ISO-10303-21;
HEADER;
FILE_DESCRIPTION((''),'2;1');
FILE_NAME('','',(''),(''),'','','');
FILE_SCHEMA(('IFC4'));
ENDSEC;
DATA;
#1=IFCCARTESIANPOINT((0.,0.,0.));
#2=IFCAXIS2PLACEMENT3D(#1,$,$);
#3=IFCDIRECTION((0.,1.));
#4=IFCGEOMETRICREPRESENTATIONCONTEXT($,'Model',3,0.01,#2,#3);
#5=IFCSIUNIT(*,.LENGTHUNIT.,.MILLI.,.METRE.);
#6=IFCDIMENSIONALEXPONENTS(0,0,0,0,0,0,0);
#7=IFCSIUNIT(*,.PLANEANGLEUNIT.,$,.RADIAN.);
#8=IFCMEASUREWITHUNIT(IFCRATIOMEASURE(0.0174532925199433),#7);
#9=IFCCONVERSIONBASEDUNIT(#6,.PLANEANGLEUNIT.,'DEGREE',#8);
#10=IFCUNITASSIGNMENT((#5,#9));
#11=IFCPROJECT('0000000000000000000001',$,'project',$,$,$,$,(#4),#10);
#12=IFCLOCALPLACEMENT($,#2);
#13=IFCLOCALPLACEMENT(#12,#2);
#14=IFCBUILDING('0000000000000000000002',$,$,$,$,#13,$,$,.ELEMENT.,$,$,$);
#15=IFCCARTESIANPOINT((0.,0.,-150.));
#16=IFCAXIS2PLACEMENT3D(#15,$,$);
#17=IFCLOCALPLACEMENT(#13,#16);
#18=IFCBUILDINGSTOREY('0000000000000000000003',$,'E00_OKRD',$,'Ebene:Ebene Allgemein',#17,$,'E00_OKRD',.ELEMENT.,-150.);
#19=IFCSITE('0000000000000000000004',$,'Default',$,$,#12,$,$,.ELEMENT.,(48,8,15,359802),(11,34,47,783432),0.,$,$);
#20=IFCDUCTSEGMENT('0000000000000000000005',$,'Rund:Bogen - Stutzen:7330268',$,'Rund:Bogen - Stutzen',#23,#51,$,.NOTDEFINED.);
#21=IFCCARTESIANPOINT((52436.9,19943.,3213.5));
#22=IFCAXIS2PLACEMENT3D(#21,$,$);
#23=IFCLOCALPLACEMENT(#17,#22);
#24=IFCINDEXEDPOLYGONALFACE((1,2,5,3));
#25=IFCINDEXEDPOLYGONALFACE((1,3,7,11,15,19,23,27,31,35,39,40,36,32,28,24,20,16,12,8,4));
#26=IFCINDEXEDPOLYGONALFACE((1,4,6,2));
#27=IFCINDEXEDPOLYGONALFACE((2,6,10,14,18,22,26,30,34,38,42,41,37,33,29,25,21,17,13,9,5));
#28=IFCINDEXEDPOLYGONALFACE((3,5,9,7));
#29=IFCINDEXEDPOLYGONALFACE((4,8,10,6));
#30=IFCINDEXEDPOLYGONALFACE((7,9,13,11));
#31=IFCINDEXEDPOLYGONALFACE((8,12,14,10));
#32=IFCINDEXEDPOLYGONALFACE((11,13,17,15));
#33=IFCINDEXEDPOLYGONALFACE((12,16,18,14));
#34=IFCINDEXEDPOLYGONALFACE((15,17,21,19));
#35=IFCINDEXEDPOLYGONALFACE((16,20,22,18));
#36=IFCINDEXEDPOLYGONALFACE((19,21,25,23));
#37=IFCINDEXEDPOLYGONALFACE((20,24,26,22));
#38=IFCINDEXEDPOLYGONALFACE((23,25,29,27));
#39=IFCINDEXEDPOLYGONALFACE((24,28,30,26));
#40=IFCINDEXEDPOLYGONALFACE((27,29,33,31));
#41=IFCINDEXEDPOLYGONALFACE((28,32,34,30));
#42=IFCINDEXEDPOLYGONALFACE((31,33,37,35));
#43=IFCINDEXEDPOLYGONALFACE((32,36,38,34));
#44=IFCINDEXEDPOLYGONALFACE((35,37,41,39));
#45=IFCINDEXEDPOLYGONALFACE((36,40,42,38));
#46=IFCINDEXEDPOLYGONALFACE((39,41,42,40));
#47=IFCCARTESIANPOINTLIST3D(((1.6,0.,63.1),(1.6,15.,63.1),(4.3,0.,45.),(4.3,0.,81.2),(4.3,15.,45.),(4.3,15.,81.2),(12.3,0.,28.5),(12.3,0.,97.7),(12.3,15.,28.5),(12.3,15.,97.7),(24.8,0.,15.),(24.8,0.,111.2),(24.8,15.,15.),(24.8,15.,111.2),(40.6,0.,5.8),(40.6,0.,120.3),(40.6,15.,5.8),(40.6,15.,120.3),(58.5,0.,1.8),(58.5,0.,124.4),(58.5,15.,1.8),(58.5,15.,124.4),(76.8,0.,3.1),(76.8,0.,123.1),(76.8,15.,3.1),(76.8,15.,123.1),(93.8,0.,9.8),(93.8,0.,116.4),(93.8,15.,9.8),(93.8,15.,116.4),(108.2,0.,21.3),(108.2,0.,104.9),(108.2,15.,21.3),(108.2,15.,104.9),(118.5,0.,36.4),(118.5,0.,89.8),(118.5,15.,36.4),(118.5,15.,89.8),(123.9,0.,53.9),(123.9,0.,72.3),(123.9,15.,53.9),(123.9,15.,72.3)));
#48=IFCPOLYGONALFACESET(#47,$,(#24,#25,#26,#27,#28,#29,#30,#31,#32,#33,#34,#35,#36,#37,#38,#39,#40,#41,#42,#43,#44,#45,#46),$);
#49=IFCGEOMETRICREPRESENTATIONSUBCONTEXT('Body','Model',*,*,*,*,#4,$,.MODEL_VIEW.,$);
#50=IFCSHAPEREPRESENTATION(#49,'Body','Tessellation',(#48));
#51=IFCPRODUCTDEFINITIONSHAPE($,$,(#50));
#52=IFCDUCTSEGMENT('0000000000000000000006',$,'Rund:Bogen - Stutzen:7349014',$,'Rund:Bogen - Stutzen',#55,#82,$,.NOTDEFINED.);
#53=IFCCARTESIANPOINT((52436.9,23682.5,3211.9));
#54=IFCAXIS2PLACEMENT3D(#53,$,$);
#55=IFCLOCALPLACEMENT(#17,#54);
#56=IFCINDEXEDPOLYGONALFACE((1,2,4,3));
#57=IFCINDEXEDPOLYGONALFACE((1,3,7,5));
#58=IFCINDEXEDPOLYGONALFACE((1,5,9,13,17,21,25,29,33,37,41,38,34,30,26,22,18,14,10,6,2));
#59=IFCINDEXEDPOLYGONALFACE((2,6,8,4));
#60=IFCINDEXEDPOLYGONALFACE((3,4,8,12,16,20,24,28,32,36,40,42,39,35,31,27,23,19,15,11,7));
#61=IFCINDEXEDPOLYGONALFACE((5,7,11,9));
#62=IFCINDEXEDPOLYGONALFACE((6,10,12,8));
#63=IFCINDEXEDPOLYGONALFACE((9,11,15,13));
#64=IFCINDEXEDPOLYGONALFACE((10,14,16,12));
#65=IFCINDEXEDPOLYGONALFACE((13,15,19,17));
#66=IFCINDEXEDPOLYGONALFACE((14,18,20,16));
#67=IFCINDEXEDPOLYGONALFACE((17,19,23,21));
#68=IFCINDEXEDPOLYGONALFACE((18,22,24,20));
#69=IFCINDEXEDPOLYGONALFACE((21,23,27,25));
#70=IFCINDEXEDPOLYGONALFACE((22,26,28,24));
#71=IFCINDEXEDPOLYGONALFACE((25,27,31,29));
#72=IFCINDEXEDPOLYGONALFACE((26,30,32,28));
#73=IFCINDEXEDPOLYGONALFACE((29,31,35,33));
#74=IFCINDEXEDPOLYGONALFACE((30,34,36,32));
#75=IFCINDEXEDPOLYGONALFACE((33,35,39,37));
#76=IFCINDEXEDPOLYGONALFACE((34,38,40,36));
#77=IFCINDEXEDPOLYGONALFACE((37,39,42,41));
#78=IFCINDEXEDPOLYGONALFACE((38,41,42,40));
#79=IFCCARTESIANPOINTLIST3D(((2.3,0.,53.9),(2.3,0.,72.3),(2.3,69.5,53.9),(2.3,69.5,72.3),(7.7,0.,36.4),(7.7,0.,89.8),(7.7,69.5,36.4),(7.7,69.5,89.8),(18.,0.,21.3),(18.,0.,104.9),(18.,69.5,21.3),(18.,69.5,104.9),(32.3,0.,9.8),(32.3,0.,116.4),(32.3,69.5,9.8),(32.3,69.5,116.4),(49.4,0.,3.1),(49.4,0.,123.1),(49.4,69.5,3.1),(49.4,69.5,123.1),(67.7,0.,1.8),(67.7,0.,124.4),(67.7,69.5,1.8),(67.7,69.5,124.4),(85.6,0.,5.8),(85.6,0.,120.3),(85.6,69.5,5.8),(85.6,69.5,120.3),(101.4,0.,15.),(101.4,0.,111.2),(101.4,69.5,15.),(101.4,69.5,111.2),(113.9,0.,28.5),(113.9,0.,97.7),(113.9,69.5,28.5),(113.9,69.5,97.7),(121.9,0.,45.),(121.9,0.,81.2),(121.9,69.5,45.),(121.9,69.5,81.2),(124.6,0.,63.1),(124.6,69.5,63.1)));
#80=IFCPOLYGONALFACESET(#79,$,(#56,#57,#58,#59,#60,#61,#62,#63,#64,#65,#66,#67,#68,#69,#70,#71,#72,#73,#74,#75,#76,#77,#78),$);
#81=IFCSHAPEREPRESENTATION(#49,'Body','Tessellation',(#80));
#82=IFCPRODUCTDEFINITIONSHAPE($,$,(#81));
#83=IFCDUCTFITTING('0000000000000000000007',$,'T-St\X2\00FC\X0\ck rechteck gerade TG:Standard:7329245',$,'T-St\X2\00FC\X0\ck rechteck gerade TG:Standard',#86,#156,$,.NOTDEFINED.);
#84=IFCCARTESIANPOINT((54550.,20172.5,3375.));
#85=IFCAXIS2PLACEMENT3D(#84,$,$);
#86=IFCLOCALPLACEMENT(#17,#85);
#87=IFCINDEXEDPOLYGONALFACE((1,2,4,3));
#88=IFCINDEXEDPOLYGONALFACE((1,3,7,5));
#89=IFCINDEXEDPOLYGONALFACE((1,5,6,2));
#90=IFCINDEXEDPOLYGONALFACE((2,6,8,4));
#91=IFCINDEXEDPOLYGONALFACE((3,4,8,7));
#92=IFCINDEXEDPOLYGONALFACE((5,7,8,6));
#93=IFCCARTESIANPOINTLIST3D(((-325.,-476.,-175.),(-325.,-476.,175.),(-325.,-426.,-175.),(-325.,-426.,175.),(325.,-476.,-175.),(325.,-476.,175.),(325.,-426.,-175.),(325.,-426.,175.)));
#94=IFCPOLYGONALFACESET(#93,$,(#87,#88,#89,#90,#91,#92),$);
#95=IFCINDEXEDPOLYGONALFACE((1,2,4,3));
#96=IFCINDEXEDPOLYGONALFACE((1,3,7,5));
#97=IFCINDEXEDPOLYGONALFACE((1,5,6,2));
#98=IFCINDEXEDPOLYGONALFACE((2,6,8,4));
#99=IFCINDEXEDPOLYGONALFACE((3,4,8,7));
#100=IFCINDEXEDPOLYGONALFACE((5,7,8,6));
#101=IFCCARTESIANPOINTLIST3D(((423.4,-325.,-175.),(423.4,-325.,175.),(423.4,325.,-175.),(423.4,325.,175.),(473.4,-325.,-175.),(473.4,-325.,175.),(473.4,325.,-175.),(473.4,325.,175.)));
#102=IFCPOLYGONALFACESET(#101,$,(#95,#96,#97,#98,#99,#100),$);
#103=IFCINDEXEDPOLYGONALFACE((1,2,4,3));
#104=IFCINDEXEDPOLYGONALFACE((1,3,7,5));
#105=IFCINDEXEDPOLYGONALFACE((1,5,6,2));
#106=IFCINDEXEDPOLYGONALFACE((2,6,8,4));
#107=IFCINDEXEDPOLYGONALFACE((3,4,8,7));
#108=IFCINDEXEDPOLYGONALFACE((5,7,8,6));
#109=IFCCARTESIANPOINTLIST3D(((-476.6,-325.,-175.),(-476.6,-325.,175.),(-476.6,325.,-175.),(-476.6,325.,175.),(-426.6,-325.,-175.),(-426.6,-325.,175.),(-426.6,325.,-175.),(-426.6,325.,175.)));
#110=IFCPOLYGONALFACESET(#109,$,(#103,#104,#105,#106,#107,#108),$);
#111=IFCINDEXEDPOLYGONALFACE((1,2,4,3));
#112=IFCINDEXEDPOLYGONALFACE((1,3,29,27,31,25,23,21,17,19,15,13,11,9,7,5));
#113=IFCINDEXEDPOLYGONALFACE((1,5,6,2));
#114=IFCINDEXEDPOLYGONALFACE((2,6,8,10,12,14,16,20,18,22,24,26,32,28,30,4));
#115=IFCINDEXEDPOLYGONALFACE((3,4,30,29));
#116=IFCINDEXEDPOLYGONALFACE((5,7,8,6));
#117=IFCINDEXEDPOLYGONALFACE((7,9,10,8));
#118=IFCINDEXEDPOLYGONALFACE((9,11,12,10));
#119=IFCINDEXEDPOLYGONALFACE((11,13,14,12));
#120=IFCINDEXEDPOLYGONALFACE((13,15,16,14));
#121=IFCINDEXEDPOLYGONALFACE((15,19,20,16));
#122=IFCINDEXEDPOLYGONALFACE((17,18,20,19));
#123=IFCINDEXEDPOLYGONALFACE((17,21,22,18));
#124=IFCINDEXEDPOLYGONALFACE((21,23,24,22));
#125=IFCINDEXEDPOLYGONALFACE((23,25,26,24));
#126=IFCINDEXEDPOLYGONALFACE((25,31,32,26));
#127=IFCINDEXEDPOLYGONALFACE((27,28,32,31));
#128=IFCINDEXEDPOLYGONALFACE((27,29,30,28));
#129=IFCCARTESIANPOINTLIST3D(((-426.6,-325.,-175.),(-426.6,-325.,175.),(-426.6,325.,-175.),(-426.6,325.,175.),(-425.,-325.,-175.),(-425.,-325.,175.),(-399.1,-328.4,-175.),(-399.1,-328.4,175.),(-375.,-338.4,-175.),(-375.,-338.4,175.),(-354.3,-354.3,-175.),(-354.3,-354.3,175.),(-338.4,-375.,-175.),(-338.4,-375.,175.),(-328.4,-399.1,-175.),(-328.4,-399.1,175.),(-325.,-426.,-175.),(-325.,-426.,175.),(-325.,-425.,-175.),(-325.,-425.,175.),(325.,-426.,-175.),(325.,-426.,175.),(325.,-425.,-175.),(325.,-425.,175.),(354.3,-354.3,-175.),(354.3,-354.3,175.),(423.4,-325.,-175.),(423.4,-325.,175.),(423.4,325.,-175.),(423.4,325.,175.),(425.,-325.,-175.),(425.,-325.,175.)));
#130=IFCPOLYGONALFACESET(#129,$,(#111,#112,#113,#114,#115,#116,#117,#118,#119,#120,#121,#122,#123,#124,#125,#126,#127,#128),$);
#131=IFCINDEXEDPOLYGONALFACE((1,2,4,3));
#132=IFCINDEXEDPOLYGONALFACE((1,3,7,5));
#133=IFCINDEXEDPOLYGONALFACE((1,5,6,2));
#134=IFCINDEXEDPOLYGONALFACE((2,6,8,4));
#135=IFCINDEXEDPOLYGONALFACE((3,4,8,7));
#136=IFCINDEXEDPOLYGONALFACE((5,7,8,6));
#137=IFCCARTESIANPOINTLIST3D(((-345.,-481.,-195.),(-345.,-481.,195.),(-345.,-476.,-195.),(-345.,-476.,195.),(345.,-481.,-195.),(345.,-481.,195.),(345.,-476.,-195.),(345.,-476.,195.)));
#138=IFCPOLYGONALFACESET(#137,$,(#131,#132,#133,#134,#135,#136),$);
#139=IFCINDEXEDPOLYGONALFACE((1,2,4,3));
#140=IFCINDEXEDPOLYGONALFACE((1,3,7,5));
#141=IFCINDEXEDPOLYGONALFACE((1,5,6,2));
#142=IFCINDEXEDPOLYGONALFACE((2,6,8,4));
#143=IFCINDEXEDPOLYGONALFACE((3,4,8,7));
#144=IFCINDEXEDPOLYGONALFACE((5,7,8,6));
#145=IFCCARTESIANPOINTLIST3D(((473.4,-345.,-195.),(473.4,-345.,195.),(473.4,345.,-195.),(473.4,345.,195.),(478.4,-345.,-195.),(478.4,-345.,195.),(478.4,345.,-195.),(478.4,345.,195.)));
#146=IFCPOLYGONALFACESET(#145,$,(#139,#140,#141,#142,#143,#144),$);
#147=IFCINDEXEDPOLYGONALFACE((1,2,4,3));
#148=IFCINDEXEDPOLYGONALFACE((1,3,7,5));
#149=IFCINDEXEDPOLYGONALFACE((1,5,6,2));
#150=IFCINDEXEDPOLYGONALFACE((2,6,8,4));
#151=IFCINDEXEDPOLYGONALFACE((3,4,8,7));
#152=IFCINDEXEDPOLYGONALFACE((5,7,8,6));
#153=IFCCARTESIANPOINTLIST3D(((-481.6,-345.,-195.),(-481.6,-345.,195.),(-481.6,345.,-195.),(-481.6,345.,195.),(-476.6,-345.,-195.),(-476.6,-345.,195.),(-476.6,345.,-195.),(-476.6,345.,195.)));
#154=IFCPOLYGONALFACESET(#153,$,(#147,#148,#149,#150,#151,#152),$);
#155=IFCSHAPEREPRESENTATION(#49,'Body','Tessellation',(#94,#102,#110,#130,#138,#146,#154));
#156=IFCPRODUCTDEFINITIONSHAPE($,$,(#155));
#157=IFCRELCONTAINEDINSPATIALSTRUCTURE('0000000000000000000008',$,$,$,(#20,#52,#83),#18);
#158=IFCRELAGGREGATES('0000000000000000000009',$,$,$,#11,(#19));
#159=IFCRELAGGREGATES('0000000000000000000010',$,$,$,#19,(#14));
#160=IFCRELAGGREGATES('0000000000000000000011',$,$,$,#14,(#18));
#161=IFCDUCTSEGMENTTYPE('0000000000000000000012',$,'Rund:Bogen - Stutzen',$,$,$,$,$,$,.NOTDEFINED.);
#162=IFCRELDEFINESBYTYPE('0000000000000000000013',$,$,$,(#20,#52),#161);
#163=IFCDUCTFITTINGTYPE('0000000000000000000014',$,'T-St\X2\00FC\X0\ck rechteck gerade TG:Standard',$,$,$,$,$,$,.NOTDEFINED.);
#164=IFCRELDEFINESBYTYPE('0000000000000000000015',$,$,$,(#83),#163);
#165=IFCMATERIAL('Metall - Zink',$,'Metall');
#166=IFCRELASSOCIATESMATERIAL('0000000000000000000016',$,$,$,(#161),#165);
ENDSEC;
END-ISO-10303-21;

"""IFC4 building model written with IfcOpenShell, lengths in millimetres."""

from ifc_helpers import new_model, entity, si_unit, converted_unit, direction, frame, frame_2d, origin, origin_2d_with_axis, place, context, subcontext, project, spatial, polyline, circle_curve, parameter, trimmed, segment, composite_curve, rectangle, circle, outline, extrude, source, transform, mapped, material, type_object, type_shapes, element, save


model = new_model("IFC4")

# Units and contexts
model_context = context("Model", 3, precision=0.01, world=origin(), true_north=direction((0.0, 1.0)))
body_context = subcontext(model_context, "Body", "Model", "MODEL_VIEW")
ifc_project = project(units=[si_unit("LENGTHUNIT", "METRE", prefix="MILLI"), converted_unit("PLANEANGLEUNIT", "DEGREE", entity("IfcRatioMeasure", 0.0174532925199433), si_unit("PLANEANGLEUNIT", "RADIAN"), dimensions=[0, 0, 0, 0, 0, 0, 0])], contexts=[model_context])

# Site, building, storey
site_placement = place(None, origin())
site = spatial("IfcSite", under=ifc_project, at=site_placement, Name="Default", CompositionType="ELEMENT", RefLatitude=(48, 8, 15, 359802), RefLongitude=(11, 34, 47, 783432), RefElevation=0.0)
building_placement = place(site_placement, origin())
building = spatial("IfcBuilding", under=site, at=building_placement, CompositionType="ELEMENT")
storey_placement = place(building_placement, frame((0.0, 0.0, -150.0)))
storey = spatial("IfcBuildingStorey", under=building, at=storey_placement, Name="E00_OKRD", ObjectType="Ebene:Ebene Allgemein", LongName="E00_OKRD", CompositionType="ELEMENT", Elevation=-150.0)

# Shared definitions
ifc_material_1 = material(Name="Metall - Zink", Category="Metall")

# Duct segments
duct_segment_type_1 = type_object("IfcDuctSegmentType", Name="Rund:Bogen - Stutzen", PredefinedType="NOTDEFINED", material=ifc_material_1)
duct_segment_1_placement = place(storey_placement, frame((52436.9, 19943.0, 3213.5)))
element("IfcDuctSegment", 1, at=duct_segment_1_placement, inside=storey, type_object=duct_segment_type_1, Name="Rund:Bogen - Stutzen:7330268", ObjectType="Rund:Bogen - Stutzen", PredefinedType="NOTDEFINED", context=body_context, shape_type="SweptSolid", body=[
    extrude(circle(Radius=61.5, at=frame_2d((0.0, 0.0), x_axis=(1.0, 0.0))), frame((63.1, 0.0, 63.1), z_axis=(0.0, 1.0, 0.0), x_axis=(-1.0, 0.0, 0.0)), (0.0, 0.0, 1.0), 15.0),
])
duct_segment_2_placement = place(storey_placement, frame((52436.9, 23682.5, 3211.9)))
element("IfcDuctSegment", 2, at=duct_segment_2_placement, inside=storey, type_object=duct_segment_type_1, Name="Rund:Bogen - Stutzen:7349014", ObjectType="Rund:Bogen - Stutzen", PredefinedType="NOTDEFINED", context=body_context, shape_type="SweptSolid", body=[
    extrude(circle(Radius=61.5, at=frame_2d((0.0, 0.0), x_axis=(1.0, 0.0))), frame((63.1, 0.0, 63.1), z_axis=(0.0, 1.0, 0.0), x_axis=(1.0, 0.0, 0.0)), (0.0, 0.0, 1.0), 69.5),
])

# Duct fitting
duct_fitting_type_1 = type_object("IfcDuctFittingType", Name="T-Stück rechteck gerade TG:Standard", PredefinedType="NOTDEFINED")
shared_shape_1 = source(origin(), body_context, "Body", "SweptSolid", [
    extrude(rectangle(XDim=50.0, YDim=650.0, at=frame_2d((0.0, 0.0), x_axis=(1.0, 0.0))), frame((0.0, -451.0, -175.0), z_axis=(0.0, 0.0, 1.0), x_axis=(0.0, -1.0, 0.0)), (0.0, 0.0, 1.0), 350.0),
    extrude(rectangle(XDim=50.0, YDim=650.0, at=origin_2d_with_axis()), frame((448.4, 0.0, -175.0), z_axis=(0.0, 0.0, 1.0), x_axis=(-1.0, 0.0, 0.0)), (0.0, 0.0, 1.0), 350.0),
    extrude(rectangle(XDim=50.0, YDim=650.0, at=frame_2d((0.0, 0.0), x_axis=(1.0, 0.0))), frame((-451.6, 0.0, -175.0)), (0.0, 0.0, 1.0), 350.0),
    extrude(outline(composite_curve([segment(trimmed(circle_curve(frame_2d((-425.6, -189.8), x_axis=(-1.0, 0.0)), 100.0), [parameter(180.0)], [parameter(270.0)], True, "PARAMETER"), False, "CONTINUOUS"), segment(polyline([(-325.6, -189.8), (-325.6, -190.8)]), True, "CONTINUOUS"), segment(polyline([(-325.6, -190.8), (324.4, -190.8)]), True, "CONTINUOUS"), segment(polyline([(324.4, -190.8), (324.4, -189.8)]), True, "CONTINUOUS"), segment(trimmed(circle_curve(frame_2d((424.4, -189.8), x_axis=(-1.0, 0.0)), 100.0), [parameter(270.0)], [parameter(0.0)], True, "PARAMETER"), False, "CONTINUOUS"), segment(polyline([(424.4, -89.8), (426.0, -89.8)]), True, "CONTINUOUS"), segment(polyline([(426.0, -89.8), (426.0, 560.2)]), True, "CONTINUOUS"), segment(polyline([(426.0, 560.2), (-424.0, 560.2)]), True, "CONTINUOUS"), segment(polyline([(-424.0, 560.2), (-424.0, -89.8)]), True, "CONTINUOUS"), segment(polyline([(-424.0, -89.8), (-425.6, -89.8)]), True, "CONTINUOUS")], self_intersect=False)), frame((-0.6, -235.2, -175.0), z_axis=(0.0, 0.0, -1.0), x_axis=(-1.0, 0.0, 0.0)), (0.0, 0.0, -1.0), 350.0),
    extrude(rectangle(XDim=5.0, YDim=690.0, at=origin_2d_with_axis()), frame((0.0, -478.5, -195.0), z_axis=(0.0, 0.0, 1.0), x_axis=(0.0, 1.0, 0.0)), (0.0, 0.0, 1.0), 390.0),
    extrude(rectangle(XDim=5.0, YDim=690.0, at=origin_2d_with_axis()), frame((475.9, 0.0, -195.0), z_axis=(0.0, 0.0, 1.0), x_axis=(-1.0, 0.0, 0.0)), (0.0, 0.0, 1.0), 390.0),
    extrude(rectangle(XDim=5.0, YDim=690.0, at=origin_2d_with_axis()), frame((-479.1, 0.0, -195.0), z_axis=(0.0, 0.0, 1.0), x_axis=(-1.0, 0.0, 0.0)), (0.0, 0.0, 1.0), 390.0),
])
type_shapes(duct_fitting_type_1, [shared_shape_1])
duct_fitting_1_placement = place(storey_placement, frame((54550.0, 20172.5, 3375.0)))
element("IfcDuctFitting", 3, at=duct_fitting_1_placement, inside=storey, type_object=duct_fitting_type_1, Name="T-Stück rechteck gerade TG:Standard:7329245", ObjectType="T-Stück rechteck gerade TG:Standard", PredefinedType="NOTDEFINED", context=body_context, shape_type="MappedRepresentation", body=[
    mapped(shared_shape_1, transform((0.0, 0.0, 0.0), scale=1.0)),
])

save(model, "model.ifc")
